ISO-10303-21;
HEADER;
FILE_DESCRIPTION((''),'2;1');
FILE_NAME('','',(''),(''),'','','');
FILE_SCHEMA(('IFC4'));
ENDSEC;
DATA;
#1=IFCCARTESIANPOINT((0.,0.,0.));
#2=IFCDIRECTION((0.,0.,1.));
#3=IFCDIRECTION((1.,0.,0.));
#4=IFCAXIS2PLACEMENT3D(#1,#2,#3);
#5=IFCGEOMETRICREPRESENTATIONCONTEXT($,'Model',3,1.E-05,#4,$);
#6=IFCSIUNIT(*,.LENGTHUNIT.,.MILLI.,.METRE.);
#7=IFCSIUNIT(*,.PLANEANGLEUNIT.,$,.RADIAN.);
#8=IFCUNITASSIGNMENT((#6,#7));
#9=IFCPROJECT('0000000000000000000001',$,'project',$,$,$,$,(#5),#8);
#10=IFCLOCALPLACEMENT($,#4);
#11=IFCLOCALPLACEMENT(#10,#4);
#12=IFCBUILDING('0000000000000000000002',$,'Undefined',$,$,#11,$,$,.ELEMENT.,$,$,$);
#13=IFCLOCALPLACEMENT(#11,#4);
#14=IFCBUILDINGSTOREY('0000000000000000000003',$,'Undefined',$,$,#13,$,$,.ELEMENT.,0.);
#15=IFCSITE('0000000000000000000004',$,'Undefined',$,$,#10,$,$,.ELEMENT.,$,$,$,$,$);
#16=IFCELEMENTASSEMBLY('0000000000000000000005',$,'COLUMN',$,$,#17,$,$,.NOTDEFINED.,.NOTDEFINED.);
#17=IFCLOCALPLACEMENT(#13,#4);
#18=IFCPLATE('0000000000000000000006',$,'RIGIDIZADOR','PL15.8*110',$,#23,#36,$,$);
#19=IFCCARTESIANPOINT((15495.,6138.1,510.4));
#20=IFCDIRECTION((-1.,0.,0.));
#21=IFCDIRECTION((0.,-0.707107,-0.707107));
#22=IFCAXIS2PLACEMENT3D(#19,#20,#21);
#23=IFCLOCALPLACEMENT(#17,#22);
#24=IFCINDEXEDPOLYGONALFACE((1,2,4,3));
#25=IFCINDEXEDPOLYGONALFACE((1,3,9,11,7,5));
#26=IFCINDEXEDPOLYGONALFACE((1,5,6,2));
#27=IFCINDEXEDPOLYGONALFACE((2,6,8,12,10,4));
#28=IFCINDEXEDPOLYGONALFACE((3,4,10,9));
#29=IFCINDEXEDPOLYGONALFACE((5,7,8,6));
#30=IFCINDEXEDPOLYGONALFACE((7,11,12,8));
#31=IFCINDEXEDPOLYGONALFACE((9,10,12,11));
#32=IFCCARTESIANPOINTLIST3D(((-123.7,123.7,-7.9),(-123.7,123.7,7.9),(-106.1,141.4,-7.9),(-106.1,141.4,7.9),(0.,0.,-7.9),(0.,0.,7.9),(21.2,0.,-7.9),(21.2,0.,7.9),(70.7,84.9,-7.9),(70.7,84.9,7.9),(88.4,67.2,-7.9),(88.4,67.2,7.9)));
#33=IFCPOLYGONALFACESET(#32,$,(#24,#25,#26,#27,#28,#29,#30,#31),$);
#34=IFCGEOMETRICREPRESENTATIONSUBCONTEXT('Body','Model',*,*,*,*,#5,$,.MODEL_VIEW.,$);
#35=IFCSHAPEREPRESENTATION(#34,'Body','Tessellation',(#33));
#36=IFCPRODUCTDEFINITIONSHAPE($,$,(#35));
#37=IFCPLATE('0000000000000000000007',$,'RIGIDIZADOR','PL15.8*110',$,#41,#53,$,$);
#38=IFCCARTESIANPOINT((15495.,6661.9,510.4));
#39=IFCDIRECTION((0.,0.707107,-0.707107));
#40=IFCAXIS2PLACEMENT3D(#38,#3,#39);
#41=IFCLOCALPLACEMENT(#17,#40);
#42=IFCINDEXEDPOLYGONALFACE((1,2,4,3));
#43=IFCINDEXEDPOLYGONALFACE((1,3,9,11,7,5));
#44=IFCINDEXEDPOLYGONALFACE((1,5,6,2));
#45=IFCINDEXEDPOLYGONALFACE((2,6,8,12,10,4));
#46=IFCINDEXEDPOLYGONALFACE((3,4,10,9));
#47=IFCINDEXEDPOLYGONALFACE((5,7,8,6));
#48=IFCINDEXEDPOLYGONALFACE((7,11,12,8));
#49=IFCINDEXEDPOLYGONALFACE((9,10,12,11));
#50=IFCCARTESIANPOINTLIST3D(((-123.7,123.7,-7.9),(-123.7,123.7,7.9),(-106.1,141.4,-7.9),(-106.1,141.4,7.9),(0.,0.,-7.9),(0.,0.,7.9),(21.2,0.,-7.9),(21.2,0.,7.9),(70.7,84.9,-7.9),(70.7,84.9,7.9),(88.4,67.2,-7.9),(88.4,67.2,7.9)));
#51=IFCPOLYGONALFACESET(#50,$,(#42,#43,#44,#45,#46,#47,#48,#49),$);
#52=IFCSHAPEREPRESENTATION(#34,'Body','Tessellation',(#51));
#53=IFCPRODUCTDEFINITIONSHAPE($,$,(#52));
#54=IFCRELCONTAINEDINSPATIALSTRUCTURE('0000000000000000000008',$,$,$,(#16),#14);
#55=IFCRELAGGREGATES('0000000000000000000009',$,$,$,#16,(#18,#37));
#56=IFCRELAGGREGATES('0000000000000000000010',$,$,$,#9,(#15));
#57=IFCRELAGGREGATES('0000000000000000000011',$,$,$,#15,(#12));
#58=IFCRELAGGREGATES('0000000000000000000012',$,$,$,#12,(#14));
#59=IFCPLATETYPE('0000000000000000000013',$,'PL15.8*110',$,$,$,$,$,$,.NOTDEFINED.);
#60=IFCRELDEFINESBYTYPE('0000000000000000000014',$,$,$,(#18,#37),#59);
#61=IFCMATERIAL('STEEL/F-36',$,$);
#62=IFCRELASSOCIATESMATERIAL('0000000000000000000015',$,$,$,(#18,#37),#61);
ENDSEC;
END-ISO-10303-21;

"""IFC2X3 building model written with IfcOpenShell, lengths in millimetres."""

from ifc_helpers import new_model, si_unit, frame, origin_with_axes, place, context, subcontext, project, spatial, polyline, outline, extrude, material, type_object, element, aggregate, save


model = new_model("IFC2X3")

# Units and contexts
model_context = context("Model", 3, precision=1e-05, world=origin_with_axes())
body_context = subcontext(model_context, "Body", "Model", "MODEL_VIEW")
ifc_project = project(units=[si_unit("LENGTHUNIT", "METRE", prefix="MILLI"), si_unit("PLANEANGLEUNIT", "RADIAN")], contexts=[model_context])

# Site, building, storey
site_placement = place(None, origin_with_axes())
site = spatial("IfcSite", under=ifc_project, at=site_placement, Name="Undefined", CompositionType="ELEMENT")
building_placement = place(site_placement, origin_with_axes())
building = spatial("IfcBuilding", under=site, at=building_placement, Name="Undefined", CompositionType="ELEMENT")
storey_placement = place(building_placement, origin_with_axes())
storey = spatial("IfcBuildingStorey", under=building, at=storey_placement, Name="Undefined", CompositionType="ELEMENT", Elevation=0.0)

# Element assembly
assembly_1_placement = place(storey_placement, origin_with_axes())
assembly_1 = element("IfcElementAssembly", 1, at=assembly_1_placement, inside=storey, Name="COLUMN", AssemblyPlace="NOTDEFINED", PredefinedType="NOTDEFINED")
ifc_material_1 = material(Name="STEEL/F-36")

# Plates
plate_type_1 = type_object("IfcPlateType", Name="PL15.8*110", PredefinedType="NOTDEFINED")
plate_1_placement = place(assembly_1_placement, frame((15495.0, 6138.1, 510.4), z_axis=(-1.0, 0.0, 0.0), x_axis=(0.0, -0.707107, -0.707107)))
plate_1 = element("IfcPlate", 2, at=plate_1_placement, type_object=plate_type_1, material=ifc_material_1, Name="RIGIDIZADOR", Description="PL15.8*110", context=body_context, shape_type="SweptSolid", body=[
    extrude(outline(polyline([(0.0, 0.0), (21.2, 0.0), (88.4, 67.2), (70.7, 84.9), (-106.1, 141.4), (-123.7, 123.7), (0.0, 0.0)])), frame((0.0, 0.0, -7.9), z_axis=(0.0, 0.0, 1.0), x_axis=(1.0, 0.0, 0.0)), (0.0, 0.0, 1.0), 15.8),
])
plate_2_placement = place(assembly_1_placement, frame((15495.0, 6661.9, 510.4), z_axis=(1.0, 0.0, 0.0), x_axis=(0.0, 0.707107, -0.707107)))
plate_2 = element("IfcPlate", 3, at=plate_2_placement, type_object=plate_type_1, material=ifc_material_1, Name="RIGIDIZADOR", Description="PL15.8*110", context=body_context, shape_type="SweptSolid", body=[
    extrude(outline(polyline([(0.0, 0.0), (21.2, 0.0), (88.4, 67.2), (70.7, 84.9), (-106.1, 141.4), (-123.7, 123.7), (0.0, 0.0)])), frame((0.0, 0.0, -7.9), z_axis=(0.0, 0.0, 1.0), x_axis=(1.0, 0.0, 0.0)), (0.0, 0.0, 1.0), 15.8),
])

aggregate(assembly_1, [plate_1, plate_2])

save(model, "model.ifc")
